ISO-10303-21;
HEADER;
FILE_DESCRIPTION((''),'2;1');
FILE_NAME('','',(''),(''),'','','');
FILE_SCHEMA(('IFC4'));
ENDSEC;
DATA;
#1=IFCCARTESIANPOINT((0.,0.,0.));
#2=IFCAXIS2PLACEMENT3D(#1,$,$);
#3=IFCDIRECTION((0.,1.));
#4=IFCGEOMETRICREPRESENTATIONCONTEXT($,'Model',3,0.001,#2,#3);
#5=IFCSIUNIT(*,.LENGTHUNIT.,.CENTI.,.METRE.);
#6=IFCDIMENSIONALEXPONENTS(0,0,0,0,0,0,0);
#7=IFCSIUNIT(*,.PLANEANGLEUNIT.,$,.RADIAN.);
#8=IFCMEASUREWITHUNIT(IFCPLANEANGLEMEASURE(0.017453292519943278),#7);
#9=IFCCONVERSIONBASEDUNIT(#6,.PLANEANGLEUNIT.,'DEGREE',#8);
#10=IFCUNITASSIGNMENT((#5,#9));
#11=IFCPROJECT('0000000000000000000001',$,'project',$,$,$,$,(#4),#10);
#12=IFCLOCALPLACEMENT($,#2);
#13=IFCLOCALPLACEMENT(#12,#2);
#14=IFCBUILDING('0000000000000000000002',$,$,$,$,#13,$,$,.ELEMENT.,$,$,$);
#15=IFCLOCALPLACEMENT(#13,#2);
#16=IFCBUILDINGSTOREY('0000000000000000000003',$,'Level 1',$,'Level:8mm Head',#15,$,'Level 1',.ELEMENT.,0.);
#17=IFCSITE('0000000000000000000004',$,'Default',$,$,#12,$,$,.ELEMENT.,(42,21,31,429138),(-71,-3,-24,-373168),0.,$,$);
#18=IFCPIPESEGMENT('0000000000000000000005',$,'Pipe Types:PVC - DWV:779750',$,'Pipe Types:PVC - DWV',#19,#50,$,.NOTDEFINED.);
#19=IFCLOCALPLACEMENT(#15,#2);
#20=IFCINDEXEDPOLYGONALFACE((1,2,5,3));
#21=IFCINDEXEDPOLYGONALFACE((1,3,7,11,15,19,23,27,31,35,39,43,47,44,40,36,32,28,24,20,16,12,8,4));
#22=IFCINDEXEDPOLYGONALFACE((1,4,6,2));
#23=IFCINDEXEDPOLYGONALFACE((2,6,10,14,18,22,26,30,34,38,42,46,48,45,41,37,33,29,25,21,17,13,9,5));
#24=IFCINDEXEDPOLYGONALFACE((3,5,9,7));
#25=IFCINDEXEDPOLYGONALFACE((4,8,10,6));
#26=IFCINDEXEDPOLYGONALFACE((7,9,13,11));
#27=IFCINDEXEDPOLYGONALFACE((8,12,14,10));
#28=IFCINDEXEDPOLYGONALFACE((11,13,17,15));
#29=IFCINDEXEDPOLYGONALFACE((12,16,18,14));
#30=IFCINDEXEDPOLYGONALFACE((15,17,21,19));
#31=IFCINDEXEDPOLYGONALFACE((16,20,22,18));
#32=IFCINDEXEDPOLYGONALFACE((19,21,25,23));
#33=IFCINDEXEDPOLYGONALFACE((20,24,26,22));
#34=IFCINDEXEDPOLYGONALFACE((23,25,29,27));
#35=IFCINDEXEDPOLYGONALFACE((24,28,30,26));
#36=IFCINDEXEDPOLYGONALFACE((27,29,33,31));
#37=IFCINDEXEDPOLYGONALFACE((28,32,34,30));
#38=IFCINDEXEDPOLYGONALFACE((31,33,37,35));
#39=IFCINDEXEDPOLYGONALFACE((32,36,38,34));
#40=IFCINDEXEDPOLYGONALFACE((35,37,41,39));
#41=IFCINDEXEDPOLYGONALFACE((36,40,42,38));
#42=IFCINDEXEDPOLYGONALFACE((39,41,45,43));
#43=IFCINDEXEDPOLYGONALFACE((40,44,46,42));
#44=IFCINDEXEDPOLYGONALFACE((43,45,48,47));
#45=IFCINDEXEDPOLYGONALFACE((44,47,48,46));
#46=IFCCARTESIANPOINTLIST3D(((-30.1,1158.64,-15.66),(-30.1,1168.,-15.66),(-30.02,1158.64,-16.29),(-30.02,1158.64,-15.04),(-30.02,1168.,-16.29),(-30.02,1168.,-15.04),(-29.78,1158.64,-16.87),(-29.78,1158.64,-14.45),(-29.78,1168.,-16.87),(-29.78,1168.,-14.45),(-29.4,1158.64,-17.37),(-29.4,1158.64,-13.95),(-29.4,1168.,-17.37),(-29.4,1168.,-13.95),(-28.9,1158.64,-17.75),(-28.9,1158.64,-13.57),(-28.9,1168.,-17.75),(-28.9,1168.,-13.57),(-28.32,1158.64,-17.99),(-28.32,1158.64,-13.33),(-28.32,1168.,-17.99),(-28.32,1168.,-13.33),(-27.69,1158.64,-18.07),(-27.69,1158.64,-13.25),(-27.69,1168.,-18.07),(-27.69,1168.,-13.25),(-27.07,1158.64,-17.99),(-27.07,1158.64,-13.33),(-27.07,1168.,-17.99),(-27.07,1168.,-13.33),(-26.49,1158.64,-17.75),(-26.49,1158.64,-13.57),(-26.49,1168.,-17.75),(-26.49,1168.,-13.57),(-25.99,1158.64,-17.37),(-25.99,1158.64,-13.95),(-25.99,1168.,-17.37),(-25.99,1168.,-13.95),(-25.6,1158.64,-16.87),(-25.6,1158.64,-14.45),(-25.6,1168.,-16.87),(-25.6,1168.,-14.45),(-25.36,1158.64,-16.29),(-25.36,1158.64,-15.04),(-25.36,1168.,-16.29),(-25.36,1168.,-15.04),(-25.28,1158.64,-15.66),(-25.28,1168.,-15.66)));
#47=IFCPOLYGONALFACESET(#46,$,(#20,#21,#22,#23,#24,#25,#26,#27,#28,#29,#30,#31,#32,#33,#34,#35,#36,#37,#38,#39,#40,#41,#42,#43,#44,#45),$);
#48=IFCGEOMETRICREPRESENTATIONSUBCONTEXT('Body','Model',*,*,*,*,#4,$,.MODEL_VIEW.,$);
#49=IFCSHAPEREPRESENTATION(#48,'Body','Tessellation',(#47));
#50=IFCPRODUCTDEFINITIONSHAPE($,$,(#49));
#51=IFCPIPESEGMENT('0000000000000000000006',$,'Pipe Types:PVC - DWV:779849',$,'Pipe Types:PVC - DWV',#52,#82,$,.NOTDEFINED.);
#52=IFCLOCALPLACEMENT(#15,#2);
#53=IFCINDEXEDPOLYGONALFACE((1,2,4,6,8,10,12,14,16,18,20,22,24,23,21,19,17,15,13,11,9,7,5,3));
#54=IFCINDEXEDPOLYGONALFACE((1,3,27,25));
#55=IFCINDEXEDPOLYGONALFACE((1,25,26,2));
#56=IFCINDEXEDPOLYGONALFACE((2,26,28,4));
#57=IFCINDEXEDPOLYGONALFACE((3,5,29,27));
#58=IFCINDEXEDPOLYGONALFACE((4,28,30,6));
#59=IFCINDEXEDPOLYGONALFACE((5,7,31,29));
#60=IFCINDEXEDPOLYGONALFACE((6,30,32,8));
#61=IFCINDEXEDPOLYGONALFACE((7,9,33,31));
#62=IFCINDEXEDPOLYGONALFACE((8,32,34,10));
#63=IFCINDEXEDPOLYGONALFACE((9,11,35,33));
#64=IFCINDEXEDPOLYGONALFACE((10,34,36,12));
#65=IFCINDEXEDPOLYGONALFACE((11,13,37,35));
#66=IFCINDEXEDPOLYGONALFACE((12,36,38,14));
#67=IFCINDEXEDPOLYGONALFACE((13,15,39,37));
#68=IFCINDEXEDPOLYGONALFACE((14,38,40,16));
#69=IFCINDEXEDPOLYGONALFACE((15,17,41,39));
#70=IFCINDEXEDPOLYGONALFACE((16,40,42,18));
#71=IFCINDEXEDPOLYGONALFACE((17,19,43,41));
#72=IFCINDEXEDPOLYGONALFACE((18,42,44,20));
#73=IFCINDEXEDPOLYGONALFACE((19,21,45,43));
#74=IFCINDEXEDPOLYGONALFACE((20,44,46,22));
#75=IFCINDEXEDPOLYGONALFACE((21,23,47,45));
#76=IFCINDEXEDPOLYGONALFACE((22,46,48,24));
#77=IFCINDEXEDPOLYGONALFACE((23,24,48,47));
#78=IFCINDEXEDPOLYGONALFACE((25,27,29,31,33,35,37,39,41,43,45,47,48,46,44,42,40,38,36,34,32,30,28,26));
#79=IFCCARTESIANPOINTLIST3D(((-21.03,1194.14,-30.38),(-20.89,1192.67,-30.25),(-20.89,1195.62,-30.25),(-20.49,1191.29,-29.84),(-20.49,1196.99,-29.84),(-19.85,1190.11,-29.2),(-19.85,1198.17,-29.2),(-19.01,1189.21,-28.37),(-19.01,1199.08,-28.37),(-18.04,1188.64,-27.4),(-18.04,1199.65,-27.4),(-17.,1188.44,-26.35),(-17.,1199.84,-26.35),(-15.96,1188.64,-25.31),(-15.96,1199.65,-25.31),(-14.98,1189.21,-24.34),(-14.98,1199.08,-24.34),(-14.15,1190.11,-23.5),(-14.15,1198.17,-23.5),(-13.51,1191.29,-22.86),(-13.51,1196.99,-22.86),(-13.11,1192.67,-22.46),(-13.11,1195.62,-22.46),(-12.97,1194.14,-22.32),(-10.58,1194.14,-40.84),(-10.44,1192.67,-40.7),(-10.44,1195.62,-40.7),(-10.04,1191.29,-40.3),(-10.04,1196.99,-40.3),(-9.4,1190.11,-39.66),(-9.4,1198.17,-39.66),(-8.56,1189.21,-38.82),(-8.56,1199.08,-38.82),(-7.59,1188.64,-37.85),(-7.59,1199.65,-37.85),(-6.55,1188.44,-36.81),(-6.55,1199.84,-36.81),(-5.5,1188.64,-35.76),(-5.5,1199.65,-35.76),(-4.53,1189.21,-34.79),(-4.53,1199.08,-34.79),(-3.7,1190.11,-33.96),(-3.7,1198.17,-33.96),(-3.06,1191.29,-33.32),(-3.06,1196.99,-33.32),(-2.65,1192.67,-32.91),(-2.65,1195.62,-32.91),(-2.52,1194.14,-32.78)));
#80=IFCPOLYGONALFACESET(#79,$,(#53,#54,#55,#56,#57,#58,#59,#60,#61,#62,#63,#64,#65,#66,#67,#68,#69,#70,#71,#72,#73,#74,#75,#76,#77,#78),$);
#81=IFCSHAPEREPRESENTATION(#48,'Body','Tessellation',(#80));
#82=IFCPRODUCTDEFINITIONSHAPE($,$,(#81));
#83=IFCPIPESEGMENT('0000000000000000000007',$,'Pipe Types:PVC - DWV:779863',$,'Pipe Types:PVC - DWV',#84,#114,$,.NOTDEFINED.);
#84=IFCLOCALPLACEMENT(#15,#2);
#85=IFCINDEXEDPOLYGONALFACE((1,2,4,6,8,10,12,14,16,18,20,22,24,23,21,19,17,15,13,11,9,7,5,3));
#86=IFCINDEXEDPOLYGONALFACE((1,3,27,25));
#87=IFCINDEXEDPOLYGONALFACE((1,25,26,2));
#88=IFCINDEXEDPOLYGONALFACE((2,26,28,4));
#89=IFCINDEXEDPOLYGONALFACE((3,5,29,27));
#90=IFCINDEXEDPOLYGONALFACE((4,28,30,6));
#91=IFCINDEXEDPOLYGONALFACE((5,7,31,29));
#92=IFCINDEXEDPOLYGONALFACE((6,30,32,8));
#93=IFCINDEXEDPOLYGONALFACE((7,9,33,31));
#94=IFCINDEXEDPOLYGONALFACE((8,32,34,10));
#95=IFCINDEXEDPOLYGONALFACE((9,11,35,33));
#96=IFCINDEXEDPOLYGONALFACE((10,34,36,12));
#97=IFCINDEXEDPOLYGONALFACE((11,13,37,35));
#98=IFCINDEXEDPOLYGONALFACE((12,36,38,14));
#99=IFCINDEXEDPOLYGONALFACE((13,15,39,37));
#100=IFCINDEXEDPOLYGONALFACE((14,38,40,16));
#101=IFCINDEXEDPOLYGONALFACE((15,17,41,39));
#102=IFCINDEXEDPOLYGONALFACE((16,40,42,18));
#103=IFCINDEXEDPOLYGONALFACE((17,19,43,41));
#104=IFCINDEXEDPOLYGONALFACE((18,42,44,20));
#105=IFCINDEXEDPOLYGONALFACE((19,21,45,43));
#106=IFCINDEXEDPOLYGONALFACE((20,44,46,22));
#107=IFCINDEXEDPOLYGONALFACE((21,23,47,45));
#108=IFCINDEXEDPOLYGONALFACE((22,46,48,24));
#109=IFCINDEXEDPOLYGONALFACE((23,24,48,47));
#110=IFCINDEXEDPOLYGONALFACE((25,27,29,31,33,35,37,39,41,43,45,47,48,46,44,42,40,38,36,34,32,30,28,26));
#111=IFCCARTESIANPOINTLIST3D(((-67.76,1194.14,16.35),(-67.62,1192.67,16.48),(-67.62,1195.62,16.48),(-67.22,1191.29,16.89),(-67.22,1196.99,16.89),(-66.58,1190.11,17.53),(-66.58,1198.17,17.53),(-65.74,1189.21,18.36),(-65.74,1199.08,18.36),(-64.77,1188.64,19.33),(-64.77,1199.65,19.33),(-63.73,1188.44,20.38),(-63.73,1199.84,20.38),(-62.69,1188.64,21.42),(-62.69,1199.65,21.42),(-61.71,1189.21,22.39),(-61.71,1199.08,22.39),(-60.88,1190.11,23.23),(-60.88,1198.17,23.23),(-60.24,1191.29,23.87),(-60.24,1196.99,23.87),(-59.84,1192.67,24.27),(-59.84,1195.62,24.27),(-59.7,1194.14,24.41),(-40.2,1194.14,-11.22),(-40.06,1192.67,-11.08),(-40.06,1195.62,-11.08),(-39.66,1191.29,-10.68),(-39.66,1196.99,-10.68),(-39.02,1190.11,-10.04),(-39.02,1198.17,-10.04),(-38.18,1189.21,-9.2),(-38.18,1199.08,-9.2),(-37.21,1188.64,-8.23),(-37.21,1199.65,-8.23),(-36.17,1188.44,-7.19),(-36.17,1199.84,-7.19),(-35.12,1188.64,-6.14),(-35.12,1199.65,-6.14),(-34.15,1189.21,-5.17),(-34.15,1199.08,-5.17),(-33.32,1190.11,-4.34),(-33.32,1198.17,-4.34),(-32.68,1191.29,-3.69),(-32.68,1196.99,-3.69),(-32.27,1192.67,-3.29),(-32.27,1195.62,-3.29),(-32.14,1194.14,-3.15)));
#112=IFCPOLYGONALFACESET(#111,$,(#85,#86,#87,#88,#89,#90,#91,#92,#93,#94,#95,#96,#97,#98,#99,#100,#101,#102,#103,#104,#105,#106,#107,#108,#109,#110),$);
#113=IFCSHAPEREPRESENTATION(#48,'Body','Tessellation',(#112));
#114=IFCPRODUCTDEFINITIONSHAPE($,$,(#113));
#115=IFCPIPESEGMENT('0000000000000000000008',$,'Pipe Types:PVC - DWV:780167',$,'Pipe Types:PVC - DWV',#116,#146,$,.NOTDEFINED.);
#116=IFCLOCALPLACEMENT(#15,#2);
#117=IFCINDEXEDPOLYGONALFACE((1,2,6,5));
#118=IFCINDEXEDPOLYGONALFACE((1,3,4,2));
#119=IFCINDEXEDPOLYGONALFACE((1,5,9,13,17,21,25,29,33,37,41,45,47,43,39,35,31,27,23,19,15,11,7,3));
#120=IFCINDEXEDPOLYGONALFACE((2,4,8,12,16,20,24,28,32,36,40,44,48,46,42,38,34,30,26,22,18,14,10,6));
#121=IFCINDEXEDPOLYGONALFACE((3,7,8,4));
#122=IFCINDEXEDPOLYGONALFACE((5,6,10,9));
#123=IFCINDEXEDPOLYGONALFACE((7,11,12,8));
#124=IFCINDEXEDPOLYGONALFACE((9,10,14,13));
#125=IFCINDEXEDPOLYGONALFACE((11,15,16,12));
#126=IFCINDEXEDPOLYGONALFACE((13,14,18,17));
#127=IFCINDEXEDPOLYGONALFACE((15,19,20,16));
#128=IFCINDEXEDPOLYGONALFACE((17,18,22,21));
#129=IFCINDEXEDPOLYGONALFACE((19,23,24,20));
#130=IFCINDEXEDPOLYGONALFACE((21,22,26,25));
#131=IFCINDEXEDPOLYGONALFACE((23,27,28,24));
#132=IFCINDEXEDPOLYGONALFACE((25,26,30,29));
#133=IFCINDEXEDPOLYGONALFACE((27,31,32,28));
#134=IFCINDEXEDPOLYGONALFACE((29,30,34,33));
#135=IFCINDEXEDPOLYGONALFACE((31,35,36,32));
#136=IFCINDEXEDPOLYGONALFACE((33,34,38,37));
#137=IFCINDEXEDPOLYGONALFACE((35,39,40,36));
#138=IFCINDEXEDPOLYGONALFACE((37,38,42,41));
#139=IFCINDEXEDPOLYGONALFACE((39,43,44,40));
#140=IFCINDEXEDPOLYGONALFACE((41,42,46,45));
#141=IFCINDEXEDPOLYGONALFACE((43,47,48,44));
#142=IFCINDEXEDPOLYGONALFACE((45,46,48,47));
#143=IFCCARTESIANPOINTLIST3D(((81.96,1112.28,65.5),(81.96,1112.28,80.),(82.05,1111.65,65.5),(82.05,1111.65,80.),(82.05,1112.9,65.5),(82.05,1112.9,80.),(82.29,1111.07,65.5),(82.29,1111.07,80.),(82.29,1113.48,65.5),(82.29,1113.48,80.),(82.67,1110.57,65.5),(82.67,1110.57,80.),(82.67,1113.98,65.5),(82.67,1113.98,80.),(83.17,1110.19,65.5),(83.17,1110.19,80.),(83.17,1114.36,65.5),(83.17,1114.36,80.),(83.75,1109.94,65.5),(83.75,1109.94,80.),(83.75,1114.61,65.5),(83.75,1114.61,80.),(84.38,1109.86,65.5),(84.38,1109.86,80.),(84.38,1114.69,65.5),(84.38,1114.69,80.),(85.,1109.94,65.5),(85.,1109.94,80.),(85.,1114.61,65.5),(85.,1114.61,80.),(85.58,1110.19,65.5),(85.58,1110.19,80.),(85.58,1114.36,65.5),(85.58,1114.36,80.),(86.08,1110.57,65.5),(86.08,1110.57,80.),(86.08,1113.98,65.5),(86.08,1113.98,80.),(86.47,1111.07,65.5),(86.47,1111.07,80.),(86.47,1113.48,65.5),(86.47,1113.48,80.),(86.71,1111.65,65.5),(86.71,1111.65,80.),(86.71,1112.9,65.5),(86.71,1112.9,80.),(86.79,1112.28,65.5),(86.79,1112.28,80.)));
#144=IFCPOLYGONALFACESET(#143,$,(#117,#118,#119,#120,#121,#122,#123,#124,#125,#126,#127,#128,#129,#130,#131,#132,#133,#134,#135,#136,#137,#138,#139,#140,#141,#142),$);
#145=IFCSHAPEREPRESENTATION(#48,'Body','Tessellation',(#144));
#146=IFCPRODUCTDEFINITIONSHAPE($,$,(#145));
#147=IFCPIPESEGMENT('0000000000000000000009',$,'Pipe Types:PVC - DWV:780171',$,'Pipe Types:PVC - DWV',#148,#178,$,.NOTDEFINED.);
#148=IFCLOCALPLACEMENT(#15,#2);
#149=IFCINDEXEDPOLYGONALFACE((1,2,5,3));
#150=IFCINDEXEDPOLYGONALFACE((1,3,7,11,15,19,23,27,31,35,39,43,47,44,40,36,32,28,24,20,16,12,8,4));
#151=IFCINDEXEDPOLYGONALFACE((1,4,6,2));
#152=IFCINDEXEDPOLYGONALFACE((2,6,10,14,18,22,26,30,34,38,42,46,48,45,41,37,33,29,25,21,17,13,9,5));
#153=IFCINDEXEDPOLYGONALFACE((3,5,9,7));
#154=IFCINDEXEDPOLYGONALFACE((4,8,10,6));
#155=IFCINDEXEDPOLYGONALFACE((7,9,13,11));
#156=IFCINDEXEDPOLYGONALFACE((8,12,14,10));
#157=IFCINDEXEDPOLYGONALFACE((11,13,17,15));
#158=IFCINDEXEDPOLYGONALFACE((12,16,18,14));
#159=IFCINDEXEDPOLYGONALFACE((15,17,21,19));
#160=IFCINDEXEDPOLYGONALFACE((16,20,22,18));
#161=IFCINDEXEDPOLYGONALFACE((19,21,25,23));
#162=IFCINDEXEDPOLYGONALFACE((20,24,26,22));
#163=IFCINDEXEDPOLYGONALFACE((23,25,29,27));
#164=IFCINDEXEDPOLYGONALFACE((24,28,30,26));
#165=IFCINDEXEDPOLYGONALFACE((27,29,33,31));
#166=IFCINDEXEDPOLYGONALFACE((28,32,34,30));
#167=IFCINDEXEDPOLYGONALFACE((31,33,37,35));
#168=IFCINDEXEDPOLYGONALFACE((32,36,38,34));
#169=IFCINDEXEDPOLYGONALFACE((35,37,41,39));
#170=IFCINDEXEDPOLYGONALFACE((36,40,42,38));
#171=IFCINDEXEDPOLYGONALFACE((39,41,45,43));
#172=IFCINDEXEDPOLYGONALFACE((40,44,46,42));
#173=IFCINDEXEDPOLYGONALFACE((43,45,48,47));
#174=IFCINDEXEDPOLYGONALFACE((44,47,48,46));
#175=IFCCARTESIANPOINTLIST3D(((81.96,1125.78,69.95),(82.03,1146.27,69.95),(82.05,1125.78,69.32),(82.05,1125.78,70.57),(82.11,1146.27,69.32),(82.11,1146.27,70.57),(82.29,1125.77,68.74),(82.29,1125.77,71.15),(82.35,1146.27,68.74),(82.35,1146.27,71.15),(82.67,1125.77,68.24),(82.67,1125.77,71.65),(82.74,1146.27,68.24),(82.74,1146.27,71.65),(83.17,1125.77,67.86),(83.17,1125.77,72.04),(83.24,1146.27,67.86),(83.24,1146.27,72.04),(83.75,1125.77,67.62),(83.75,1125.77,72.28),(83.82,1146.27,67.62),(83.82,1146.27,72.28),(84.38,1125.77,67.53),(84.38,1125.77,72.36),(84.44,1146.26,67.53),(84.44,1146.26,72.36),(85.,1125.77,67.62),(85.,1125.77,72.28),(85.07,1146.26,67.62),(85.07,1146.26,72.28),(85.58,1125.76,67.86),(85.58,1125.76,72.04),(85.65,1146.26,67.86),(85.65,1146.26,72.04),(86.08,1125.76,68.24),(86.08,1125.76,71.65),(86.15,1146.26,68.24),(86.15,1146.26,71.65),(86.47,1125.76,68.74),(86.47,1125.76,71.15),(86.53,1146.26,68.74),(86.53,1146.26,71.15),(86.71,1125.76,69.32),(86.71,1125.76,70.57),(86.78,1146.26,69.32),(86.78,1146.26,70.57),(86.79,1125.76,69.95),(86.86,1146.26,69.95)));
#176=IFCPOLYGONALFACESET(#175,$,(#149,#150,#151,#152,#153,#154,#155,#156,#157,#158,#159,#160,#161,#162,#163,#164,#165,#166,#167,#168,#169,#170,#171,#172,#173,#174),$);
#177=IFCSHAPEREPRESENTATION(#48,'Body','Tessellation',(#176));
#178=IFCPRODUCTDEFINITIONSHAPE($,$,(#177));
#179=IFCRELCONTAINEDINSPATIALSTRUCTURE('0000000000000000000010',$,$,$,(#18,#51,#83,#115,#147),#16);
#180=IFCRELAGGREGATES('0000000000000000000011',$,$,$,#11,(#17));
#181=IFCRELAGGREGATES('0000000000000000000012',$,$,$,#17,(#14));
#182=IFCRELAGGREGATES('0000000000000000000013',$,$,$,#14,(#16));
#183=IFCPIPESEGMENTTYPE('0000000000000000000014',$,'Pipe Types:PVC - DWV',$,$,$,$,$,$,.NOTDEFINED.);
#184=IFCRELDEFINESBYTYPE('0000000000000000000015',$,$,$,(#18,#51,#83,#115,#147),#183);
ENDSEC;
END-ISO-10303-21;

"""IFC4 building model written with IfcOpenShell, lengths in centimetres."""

from ifc_helpers import new_model, entity, si_unit, converted_unit, direction, frame, origin, place, context, subcontext, project, spatial, arc, indexed_curve, outline, extrude, type_object, element, save


model = new_model("IFC4")

# Units and contexts
model_context = context("Model", 3, precision=0.001, world=origin(), true_north=direction((0.0, 1.0)))
body_context = subcontext(model_context, "Body", "Model", "MODEL_VIEW")
ifc_project = project(units=[si_unit("LENGTHUNIT", "METRE", prefix="CENTI"), converted_unit("PLANEANGLEUNIT", "DEGREE", entity("IfcPlaneAngleMeasure", 0.017453292519943278), si_unit("PLANEANGLEUNIT", "RADIAN"), dimensions=[0, 0, 0, 0, 0, 0, 0])], contexts=[model_context])

# Site, building, storey
site_placement = place(None, origin())
site = spatial("IfcSite", under=ifc_project, at=site_placement, Name="Default", CompositionType="ELEMENT", RefLatitude=(42, 21, 31, 429138), RefLongitude=(-71, -3, -24, -373168), RefElevation=0.0)
building_placement = place(site_placement, origin())
building = spatial("IfcBuilding", under=site, at=building_placement, CompositionType="ELEMENT")
storey_placement = place(building_placement, origin())
storey = spatial("IfcBuildingStorey", under=building, at=storey_placement, Name="Level 1", ObjectType="Level:8mm Head", LongName="Level 1", CompositionType="ELEMENT", Elevation=0.0)

# Pipe segments
pipe_segment_type = type_object("IfcPipeSegmentType", Name="Pipe Types:PVC - DWV", PredefinedType="NOTDEFINED")
pipe_segment_1_placement = place(storey_placement, origin())
element("IfcPipeSegment", 1, at=pipe_segment_1_placement, inside=storey, type_object=pipe_segment_type, Name="Pipe Types:PVC - DWV:779750", ObjectType="Pipe Types:PVC - DWV", PredefinedType="NOTDEFINED", context=body_context, shape_type="SweptSolid", body=[
    extrude(outline(indexed_curve([(2.41, 0.0), (1.71, 1.71), (0.0, 2.41), (-1.71, 1.71), (-2.41, 0.0), (-1.71, -1.71), (0.0, -2.41), (1.71, -1.71)], segments=[arc(1, 2, 3), arc(3, 4, 5), arc(5, 6, 7), arc(7, 8, 1)], self_intersect=False)), frame((-27.69, 1158.64, -15.66), z_axis=(0.0, 1.0, 0.0), x_axis=(1.0, 0.0, 0.0)), (0.0, 0.0, 1.0), 9.36),
])
pipe_segment_2_placement = place(storey_placement, origin())
element("IfcPipeSegment", 2, at=pipe_segment_2_placement, inside=storey, type_object=pipe_segment_type, Name="Pipe Types:PVC - DWV:779849", ObjectType="Pipe Types:PVC - DWV", PredefinedType="NOTDEFINED", context=body_context, shape_type="SweptSolid", body=[
    extrude(outline(indexed_curve([(5.7, 0.0), (4.03, 4.03), (0.0, 5.7), (-4.03, 4.03), (-5.7, 0.0), (-4.03, -4.03), (0.0, -5.7), (4.03, -4.03)], segments=[arc(1, 2, 3), arc(3, 4, 5), arc(5, 6, 7), arc(7, 8, 1)], self_intersect=False)), frame((-6.55, 1194.14, -36.81), z_axis=(-0.707107, 0.0, 0.707107), x_axis=(0.0, -1.0, 0.0)), (0.0, 0.0, 1.0), 14.78),
])
pipe_segment_3_placement = place(storey_placement, origin())
element("IfcPipeSegment", 3, at=pipe_segment_3_placement, inside=storey, type_object=pipe_segment_type, Name="Pipe Types:PVC - DWV:779863", ObjectType="Pipe Types:PVC - DWV", PredefinedType="NOTDEFINED", context=body_context, shape_type="SweptSolid", body=[
    extrude(outline(indexed_curve([(5.7, 0.0), (4.03, 4.03), (0.0, 5.7), (-4.03, 4.03), (-5.7, 0.0), (-4.03, -4.03), (0.0, -5.7), (4.03, -4.03)], segments=[arc(1, 2, 3), arc(3, 4, 5), arc(5, 6, 7), arc(7, 8, 1)], self_intersect=False)), frame((-63.73, 1194.14, 20.38), z_axis=(0.707107, 0.0, -0.707107), x_axis=(0.0, -1.0, 0.0)), (0.0, 0.0, 1.0), 38.98),
])
pipe_segment_4_placement = place(storey_placement, origin())
element("IfcPipeSegment", 4, at=pipe_segment_4_placement, inside=storey, type_object=pipe_segment_type, Name="Pipe Types:PVC - DWV:780167", ObjectType="Pipe Types:PVC - DWV", PredefinedType="NOTDEFINED", context=body_context, shape_type="SweptSolid", body=[
    extrude(outline(indexed_curve([(2.41, 0.0), (1.71, 1.71), (0.0, 2.41), (-1.71, 1.71), (-2.41, 0.0), (-1.71, -1.71), (0.0, -2.41), (1.71, -1.71)], segments=[arc(1, 2, 3), arc(3, 4, 5), arc(5, 6, 7), arc(7, 8, 1)], self_intersect=False)), frame((84.38, 1112.28, 65.5)), (0.0, 0.0, 1.0), 14.5),
])
pipe_segment_5_placement = place(storey_placement, origin())
element("IfcPipeSegment", 5, at=pipe_segment_5_placement, inside=storey, type_object=pipe_segment_type, Name="Pipe Types:PVC - DWV:780171", ObjectType="Pipe Types:PVC - DWV", PredefinedType="NOTDEFINED", context=body_context, shape_type="SweptSolid", body=[
    extrude(outline(indexed_curve([(2.41, 0.0), (1.71, 1.71), (0.0, 2.41), (-1.71, 1.71), (-2.41, 0.0), (-1.71, -1.71), (0.0, -2.41), (1.71, -1.71)], segments=[arc(1, 2, 3), arc(3, 4, 5), arc(5, 6, 7), arc(7, 8, 1)], self_intersect=False)), frame((84.38, 1125.77, 69.95), z_axis=(0.003331, 0.999994, 0.0), x_axis=(0.999994, -0.003331, 0.0)), (0.0, 0.0, 1.0), 20.5),
])

save(model, "model.ifc")
